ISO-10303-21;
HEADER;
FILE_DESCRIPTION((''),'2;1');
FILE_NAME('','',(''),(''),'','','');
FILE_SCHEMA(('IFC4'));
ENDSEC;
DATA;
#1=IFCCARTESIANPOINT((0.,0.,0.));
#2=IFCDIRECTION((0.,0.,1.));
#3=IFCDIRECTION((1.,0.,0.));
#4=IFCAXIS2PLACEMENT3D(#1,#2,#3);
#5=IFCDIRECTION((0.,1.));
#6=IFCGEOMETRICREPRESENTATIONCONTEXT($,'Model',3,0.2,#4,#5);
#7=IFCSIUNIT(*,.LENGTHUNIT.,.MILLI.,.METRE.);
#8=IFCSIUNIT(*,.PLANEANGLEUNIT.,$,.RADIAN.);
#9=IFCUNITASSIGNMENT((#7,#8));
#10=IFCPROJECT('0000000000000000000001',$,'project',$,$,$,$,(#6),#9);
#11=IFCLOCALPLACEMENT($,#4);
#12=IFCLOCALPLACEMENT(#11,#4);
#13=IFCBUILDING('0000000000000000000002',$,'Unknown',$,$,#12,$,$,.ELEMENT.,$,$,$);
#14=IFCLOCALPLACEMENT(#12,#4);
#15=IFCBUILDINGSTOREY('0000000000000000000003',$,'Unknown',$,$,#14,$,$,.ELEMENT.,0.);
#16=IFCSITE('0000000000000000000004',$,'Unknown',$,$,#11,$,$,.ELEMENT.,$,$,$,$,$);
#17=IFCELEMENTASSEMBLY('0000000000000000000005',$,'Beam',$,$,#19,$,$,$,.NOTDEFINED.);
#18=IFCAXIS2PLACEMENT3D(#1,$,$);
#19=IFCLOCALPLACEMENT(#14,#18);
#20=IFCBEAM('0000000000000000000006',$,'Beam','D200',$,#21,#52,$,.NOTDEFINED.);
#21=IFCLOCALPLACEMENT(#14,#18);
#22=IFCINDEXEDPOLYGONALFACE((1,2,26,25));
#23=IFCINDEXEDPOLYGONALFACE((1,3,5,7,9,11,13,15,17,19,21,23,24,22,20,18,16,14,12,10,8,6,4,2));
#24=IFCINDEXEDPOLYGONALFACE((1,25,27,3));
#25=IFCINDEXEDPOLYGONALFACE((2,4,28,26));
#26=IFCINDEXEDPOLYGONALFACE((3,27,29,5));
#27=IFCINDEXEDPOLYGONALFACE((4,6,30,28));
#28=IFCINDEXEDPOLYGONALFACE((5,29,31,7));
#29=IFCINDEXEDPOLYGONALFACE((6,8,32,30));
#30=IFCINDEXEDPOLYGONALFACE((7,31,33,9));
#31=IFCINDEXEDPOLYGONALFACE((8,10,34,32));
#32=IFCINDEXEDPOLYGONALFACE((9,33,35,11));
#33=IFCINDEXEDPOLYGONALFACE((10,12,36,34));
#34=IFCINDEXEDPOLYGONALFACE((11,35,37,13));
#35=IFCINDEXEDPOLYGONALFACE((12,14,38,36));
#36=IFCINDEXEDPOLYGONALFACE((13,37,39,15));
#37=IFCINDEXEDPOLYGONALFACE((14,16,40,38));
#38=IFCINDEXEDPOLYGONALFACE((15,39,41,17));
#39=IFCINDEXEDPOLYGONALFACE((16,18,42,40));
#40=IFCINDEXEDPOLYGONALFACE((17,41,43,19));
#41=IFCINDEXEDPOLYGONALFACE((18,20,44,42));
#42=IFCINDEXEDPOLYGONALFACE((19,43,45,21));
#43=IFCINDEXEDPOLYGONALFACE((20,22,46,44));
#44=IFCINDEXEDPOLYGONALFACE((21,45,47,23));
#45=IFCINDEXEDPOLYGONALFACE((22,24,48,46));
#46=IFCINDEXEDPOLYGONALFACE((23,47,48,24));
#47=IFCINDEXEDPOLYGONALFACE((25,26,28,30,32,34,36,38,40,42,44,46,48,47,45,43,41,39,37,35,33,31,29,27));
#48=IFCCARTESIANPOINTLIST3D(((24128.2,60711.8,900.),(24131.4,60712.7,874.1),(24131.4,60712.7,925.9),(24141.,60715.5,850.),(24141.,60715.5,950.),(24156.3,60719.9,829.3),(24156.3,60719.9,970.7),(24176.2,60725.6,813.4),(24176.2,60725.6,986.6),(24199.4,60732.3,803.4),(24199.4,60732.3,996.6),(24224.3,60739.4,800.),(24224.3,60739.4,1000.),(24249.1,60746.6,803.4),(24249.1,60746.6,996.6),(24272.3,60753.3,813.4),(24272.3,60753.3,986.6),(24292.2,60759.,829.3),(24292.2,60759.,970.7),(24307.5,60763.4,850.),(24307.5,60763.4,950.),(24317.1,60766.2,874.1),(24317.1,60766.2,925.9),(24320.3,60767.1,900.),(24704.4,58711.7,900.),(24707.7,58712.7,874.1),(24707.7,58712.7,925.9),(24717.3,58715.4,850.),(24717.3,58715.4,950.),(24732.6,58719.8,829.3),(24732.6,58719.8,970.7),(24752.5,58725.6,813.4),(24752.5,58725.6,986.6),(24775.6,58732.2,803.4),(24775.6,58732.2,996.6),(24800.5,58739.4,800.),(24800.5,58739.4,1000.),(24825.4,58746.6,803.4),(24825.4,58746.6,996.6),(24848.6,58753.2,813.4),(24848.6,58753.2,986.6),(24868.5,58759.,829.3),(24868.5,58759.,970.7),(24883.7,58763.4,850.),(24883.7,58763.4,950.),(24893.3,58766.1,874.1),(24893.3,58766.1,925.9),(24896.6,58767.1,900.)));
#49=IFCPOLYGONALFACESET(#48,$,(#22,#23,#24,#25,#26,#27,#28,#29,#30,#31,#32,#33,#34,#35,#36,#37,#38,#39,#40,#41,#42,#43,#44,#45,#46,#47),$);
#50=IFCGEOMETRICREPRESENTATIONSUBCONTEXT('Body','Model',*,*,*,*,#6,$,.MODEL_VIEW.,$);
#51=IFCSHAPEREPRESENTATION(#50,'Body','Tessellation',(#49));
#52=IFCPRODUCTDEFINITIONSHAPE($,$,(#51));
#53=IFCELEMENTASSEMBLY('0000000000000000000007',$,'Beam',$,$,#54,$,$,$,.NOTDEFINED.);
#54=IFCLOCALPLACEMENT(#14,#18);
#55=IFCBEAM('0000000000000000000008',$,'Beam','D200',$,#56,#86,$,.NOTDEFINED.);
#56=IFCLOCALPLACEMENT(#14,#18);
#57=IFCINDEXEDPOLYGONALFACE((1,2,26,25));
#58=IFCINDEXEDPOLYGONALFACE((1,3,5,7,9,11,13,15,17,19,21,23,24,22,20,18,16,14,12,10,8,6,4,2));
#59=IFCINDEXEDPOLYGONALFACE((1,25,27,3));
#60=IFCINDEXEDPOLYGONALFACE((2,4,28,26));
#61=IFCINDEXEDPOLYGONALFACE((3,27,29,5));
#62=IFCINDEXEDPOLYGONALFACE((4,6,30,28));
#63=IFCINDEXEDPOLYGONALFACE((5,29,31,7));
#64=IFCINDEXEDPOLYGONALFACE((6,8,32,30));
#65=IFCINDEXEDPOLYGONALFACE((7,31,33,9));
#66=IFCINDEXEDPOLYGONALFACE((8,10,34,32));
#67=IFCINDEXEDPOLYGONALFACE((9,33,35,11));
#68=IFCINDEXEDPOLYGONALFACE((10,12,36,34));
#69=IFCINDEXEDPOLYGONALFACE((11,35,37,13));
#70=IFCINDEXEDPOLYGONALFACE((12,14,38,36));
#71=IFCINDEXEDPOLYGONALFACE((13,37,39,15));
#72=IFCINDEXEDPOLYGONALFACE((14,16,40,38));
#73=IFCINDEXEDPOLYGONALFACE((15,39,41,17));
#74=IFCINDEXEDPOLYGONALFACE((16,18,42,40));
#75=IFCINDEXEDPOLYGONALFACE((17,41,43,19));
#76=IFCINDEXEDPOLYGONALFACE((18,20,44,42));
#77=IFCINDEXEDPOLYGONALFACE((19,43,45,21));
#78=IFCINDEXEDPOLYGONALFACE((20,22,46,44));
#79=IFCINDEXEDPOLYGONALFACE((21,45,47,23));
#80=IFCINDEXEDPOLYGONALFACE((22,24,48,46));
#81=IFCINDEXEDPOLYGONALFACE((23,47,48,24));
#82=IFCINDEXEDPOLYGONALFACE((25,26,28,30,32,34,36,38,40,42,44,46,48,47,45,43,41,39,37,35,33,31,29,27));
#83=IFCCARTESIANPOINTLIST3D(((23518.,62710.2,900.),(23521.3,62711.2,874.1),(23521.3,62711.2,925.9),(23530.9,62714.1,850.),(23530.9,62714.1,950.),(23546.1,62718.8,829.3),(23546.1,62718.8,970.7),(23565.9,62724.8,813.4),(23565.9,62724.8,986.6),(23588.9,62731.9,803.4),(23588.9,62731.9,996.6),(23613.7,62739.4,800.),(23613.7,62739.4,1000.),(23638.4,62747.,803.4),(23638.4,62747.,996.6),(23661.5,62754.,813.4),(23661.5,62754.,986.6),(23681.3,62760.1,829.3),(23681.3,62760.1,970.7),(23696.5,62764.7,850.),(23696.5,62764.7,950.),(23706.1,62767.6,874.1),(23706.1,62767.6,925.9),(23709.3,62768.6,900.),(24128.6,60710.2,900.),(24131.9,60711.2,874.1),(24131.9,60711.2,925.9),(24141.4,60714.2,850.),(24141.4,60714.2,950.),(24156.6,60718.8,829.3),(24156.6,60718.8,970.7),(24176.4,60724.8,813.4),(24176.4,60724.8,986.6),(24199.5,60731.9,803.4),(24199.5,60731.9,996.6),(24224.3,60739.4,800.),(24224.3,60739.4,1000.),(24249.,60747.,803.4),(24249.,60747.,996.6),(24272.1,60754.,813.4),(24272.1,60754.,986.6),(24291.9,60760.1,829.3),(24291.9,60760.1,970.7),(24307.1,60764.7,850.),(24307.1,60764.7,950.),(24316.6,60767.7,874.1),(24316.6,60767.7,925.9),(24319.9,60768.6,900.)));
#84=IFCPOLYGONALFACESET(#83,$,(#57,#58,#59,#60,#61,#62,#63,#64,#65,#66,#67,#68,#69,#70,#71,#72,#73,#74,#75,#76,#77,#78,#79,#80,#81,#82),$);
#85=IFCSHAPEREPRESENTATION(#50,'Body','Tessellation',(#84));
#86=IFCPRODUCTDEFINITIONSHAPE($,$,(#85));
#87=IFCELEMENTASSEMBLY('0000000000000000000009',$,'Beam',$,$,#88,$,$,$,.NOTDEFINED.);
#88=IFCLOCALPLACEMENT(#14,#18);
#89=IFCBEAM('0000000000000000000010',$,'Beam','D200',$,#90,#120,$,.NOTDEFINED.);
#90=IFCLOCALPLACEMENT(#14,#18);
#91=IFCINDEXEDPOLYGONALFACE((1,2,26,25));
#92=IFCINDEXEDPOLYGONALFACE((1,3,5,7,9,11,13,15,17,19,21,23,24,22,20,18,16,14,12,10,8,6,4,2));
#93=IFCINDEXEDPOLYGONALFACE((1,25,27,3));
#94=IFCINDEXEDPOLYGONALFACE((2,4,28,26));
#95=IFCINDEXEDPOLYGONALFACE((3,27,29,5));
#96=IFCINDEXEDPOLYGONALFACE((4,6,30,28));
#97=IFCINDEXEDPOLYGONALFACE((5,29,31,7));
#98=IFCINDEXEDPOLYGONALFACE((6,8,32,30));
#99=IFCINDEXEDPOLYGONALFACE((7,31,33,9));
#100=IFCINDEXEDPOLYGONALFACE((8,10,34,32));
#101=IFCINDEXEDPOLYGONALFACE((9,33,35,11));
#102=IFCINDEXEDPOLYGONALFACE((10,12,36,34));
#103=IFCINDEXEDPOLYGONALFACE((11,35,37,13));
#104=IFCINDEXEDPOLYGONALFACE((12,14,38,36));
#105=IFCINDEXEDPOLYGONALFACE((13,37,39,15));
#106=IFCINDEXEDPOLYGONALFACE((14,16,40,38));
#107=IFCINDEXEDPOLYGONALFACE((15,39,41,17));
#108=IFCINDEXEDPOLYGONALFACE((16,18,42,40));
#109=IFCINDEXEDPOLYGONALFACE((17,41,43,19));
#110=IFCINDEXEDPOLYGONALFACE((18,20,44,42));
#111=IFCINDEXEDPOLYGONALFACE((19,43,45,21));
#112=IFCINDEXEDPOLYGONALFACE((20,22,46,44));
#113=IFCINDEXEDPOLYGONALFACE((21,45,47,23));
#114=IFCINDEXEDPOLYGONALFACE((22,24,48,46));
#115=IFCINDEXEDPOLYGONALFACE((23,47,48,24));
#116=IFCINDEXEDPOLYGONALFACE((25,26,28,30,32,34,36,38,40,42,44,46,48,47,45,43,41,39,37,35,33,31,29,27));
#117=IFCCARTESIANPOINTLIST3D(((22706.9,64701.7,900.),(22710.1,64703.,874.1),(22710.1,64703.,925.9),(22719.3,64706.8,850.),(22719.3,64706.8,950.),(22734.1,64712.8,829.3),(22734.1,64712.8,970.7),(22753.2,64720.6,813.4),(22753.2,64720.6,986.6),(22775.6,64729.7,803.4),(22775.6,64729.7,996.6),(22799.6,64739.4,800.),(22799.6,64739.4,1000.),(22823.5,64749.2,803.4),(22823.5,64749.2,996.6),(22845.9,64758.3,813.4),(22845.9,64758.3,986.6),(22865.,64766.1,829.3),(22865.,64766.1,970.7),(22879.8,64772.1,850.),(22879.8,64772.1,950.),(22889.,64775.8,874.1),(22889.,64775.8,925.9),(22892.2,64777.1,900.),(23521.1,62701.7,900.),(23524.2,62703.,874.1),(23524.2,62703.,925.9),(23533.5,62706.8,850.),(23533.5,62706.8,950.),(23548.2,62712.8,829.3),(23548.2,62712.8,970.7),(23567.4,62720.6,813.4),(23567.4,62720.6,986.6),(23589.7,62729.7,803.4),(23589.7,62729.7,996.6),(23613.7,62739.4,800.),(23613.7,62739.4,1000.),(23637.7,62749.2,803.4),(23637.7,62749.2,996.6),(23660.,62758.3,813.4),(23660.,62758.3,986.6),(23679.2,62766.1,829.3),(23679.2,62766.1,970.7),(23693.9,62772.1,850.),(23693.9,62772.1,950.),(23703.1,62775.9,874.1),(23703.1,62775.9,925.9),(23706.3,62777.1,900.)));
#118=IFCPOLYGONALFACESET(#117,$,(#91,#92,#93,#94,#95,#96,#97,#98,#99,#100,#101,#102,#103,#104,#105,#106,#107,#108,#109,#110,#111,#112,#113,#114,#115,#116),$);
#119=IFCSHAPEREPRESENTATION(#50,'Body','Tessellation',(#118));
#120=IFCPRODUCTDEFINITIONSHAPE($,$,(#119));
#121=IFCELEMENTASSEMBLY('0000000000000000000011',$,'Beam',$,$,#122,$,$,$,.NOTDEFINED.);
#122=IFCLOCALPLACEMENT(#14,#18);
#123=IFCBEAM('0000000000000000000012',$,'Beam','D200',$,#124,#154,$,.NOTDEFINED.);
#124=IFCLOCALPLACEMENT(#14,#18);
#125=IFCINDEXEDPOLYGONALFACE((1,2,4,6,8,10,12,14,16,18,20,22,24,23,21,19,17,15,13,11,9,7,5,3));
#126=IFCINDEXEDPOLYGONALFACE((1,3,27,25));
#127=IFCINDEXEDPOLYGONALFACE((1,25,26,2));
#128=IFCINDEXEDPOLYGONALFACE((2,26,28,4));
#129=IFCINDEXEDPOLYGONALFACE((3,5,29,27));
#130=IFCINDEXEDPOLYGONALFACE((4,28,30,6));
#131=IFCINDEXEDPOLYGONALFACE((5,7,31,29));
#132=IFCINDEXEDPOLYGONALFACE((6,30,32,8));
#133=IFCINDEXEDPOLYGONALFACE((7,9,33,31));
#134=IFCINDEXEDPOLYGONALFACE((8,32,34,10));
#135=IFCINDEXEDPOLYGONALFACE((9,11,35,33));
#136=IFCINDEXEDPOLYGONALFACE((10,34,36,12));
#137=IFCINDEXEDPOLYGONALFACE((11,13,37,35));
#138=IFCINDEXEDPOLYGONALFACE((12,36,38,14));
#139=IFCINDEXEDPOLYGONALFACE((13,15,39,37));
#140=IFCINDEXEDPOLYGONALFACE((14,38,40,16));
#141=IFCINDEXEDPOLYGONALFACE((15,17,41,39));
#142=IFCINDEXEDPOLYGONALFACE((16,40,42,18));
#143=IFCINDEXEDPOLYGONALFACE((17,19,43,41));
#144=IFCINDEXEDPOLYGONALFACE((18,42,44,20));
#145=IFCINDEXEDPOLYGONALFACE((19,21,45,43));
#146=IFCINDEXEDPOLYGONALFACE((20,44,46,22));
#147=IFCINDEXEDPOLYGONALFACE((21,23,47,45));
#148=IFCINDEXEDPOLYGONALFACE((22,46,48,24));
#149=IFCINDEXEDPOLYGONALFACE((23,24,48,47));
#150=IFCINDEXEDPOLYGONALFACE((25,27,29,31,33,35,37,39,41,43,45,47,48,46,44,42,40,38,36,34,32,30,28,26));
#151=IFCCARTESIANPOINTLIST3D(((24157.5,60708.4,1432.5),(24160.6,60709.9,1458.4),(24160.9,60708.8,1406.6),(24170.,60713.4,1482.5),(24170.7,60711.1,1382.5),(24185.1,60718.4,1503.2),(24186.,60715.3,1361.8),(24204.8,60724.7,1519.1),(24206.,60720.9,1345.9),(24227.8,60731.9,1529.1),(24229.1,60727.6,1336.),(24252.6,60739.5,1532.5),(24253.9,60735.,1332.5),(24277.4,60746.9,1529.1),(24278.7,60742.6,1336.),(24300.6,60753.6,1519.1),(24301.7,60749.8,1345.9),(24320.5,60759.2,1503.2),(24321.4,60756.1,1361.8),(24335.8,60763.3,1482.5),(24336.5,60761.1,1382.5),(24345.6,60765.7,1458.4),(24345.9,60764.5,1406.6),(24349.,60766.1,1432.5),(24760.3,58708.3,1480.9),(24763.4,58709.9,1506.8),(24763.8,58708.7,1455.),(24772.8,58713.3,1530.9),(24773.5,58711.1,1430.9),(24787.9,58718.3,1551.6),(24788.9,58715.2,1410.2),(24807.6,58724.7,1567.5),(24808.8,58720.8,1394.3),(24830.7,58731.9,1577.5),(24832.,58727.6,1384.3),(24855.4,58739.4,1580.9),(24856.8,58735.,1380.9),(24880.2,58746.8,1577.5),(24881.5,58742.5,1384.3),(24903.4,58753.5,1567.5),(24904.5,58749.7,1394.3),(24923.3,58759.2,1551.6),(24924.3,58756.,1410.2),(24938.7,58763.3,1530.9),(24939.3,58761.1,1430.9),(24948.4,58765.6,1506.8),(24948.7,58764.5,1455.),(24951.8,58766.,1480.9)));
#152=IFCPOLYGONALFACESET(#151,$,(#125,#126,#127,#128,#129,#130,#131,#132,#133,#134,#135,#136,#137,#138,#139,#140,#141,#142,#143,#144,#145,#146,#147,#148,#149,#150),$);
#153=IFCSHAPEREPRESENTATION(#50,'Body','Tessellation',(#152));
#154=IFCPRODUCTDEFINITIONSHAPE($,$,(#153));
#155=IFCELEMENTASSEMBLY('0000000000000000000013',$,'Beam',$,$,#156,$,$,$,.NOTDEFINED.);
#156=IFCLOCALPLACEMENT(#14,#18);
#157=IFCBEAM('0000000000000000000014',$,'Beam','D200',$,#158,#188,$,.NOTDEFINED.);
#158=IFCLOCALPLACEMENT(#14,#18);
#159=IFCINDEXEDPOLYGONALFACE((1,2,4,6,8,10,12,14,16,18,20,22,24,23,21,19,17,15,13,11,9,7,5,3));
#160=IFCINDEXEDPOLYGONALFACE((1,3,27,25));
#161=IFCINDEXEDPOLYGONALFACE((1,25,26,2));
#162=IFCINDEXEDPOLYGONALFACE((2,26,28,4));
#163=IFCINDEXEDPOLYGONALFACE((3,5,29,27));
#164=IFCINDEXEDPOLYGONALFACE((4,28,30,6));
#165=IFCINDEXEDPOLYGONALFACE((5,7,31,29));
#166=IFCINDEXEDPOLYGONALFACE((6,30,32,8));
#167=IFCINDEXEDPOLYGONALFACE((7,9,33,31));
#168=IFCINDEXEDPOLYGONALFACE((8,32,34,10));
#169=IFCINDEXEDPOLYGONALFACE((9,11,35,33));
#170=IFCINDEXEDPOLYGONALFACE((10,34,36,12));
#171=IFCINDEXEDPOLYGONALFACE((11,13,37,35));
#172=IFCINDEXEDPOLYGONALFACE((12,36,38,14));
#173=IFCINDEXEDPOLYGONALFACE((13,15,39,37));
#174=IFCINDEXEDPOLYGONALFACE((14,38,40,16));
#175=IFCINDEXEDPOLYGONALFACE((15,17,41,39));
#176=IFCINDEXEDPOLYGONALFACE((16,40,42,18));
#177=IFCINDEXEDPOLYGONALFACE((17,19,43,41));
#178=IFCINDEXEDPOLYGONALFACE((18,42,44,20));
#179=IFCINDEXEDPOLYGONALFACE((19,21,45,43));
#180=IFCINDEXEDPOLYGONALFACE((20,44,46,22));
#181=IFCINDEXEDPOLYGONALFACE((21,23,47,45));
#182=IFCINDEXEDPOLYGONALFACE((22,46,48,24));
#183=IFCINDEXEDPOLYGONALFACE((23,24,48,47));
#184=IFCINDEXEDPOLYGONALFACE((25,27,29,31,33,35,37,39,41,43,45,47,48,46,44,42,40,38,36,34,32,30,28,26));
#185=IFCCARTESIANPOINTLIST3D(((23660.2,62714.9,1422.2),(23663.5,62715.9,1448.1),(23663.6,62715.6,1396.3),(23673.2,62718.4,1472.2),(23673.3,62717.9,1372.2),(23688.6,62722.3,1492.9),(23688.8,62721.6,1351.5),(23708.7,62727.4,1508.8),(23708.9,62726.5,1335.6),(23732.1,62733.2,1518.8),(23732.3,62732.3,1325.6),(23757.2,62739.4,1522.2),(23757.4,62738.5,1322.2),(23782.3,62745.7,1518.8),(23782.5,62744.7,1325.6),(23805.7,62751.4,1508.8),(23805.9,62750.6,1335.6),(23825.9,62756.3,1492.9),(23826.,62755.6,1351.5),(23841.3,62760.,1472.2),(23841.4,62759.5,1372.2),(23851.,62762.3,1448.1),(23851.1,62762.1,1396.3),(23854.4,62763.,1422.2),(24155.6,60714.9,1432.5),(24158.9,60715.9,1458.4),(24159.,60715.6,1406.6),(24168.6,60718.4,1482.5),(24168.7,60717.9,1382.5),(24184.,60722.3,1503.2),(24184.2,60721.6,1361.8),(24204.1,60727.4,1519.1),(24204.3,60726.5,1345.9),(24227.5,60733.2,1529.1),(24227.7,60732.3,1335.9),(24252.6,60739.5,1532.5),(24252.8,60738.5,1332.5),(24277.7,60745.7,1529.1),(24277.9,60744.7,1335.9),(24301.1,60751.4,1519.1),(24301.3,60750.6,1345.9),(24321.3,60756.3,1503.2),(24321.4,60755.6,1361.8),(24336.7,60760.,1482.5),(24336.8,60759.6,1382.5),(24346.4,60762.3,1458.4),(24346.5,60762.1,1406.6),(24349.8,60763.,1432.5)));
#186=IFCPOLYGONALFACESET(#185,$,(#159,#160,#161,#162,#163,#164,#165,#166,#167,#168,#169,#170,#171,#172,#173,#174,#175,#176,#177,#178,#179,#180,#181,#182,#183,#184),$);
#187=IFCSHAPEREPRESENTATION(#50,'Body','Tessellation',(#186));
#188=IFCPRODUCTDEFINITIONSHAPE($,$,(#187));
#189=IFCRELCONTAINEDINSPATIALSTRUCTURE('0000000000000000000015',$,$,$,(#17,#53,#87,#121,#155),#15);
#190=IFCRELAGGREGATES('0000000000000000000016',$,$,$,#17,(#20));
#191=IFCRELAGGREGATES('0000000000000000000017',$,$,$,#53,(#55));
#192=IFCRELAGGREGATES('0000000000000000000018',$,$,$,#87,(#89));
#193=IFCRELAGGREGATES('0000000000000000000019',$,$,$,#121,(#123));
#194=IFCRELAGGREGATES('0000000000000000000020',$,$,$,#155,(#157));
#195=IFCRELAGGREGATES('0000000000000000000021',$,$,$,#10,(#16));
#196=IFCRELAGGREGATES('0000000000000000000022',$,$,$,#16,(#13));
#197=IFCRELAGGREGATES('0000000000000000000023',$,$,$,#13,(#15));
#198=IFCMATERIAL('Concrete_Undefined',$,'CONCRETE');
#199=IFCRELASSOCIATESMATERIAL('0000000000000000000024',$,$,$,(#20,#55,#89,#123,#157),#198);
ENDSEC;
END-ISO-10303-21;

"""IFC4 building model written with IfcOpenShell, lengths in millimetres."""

from ifc_helpers import new_model, si_unit, direction, frame, origin_with_axes, place, context, subcontext, project, spatial, line, indexed_curve, outline, extrude, material, element, aggregate, save


model = new_model("IFC4")

# Units and contexts
model_context = context("Model", 3, precision=0.2, world=origin_with_axes(), true_north=direction((0.0, 1.0)))
body_context = subcontext(model_context, "Body", "Model", "MODEL_VIEW")
ifc_project = project(units=[si_unit("LENGTHUNIT", "METRE", prefix="MILLI"), si_unit("PLANEANGLEUNIT", "RADIAN")], contexts=[model_context])

# Site, building, storey
site_placement = place(None, origin_with_axes())
site = spatial("IfcSite", under=ifc_project, at=site_placement, Name="Unknown", CompositionType="ELEMENT")
building_placement = place(site_placement, origin_with_axes())
building = spatial("IfcBuilding", under=site, at=building_placement, Name="Unknown", CompositionType="ELEMENT")
storey_placement = place(building_placement, origin_with_axes())
storey = spatial("IfcBuildingStorey", under=building, at=storey_placement, Name="Unknown", CompositionType="ELEMENT", Elevation=0.0)

# Element assemblies, beams
assembly_1_placement = place(storey_placement, frame((24224.3, 60739.4, 900.0), z_axis=(-0.960911, -0.276858, 0.0), x_axis=(0.276858, -0.960911, 0.0)))
assembly_1 = element("IfcElementAssembly", 1, at=assembly_1_placement, inside=storey, Name="Beam", PredefinedType="NOTDEFINED")
ifc_material = material(Name="Concrete_Undefined", Category="CONCRETE")
beam_1_placement = place(assembly_1_placement, origin_with_axes())
beam_1 = element("IfcBeam", 2, at=beam_1_placement, material=ifc_material, Name="Beam", Description="D200", PredefinedType="NOTDEFINED", context=body_context, shape_type="SolidModel", body=[
    extrude(outline(indexed_curve([(100.0, 0.0), (96.6, 25.9), (86.6, 50.0), (70.7, 70.7), (50.0, 86.6), (25.9, 96.6), (0.0, 100.0), (-25.9, 96.6), (-50.0, 86.6), (-70.7, 70.7), (-86.6, 50.0), (-96.6, 25.9), (-100.0, 0.0), (-96.6, -25.9), (-86.6, -50.0), (-70.7, -70.7), (-50.0, -86.6), (-25.9, -96.6), (0.0, -100.0), (25.9, -96.6), (50.0, -86.6), (70.7, -70.7), (86.6, -50.0), (96.6, -25.9)], segments=[line(1, 2, 3, 4, 5, 6, 7, 8, 9, 10, 11, 12, 13, 14, 15, 16, 17, 18, 19, 20, 21, 22, 23, 24, 1)])), frame((0.0, 0.0, 0.0), z_axis=(-1.0, 0.0, 0.0), x_axis=(0.0, 0.0, 1.0)), (0.0, 0.0, -1.0), 2081.4),
])
aggregate(assembly_1, [beam_1])
assembly_2_placement = place(storey_placement, frame((23613.7, 62739.4, 900.0), z_axis=(-0.956423, -0.291984, 0.0), x_axis=(0.291984, -0.956423, 0.0)))
assembly_2 = element("IfcElementAssembly", 3, at=assembly_2_placement, inside=storey, Name="Beam", PredefinedType="NOTDEFINED")
beam_2_placement = place(assembly_2_placement, origin_with_axes())
beam_2 = element("IfcBeam", 4, at=beam_2_placement, material=ifc_material, Name="Beam", Description="D200", PredefinedType="NOTDEFINED", context=body_context, shape_type="SolidModel", body=[
    extrude(outline(indexed_curve([(100.0, 0.0), (96.6, 25.9), (86.6, 50.0), (70.7, 70.7), (50.0, 86.6), (25.9, 96.6), (0.0, 100.0), (-25.9, 96.6), (-50.0, 86.6), (-70.7, 70.7), (-86.6, 50.0), (-96.6, 25.9), (-100.0, 0.0), (-96.6, -25.9), (-86.6, -50.0), (-70.7, -70.7), (-50.0, -86.6), (-25.9, -96.6), (0.0, -100.0), (25.9, -96.6), (50.0, -86.6), (70.7, -70.7), (86.6, -50.0), (96.6, -25.9)], segments=[line(1, 2, 3, 4, 5, 6, 7, 8, 9, 10, 11, 12, 13, 14, 15, 16, 17, 18, 19, 20, 21, 22, 23, 24, 1)])), frame((0.0, 0.0, 0.0), z_axis=(-1.0, 0.0, 0.0), x_axis=(0.0, 0.0, 1.0)), (0.0, 0.0, -1.0), 2091.1),
])
aggregate(assembly_2, [beam_2])
assembly_3_placement = place(storey_placement, frame((22799.6, 64739.4, 900.0), z_axis=(-0.926202, -0.377027, 0.0), x_axis=(0.377027, -0.926202, 0.0)))
assembly_3 = element("IfcElementAssembly", 5, at=assembly_3_placement, inside=storey, Name="Beam", PredefinedType="NOTDEFINED")
beam_3_placement = place(assembly_3_placement, origin_with_axes())
beam_3 = element("IfcBeam", 6, at=beam_3_placement, material=ifc_material, Name="Beam", Description="D200", PredefinedType="NOTDEFINED", context=body_context, shape_type="SolidModel", body=[
    extrude(outline(indexed_curve([(100.0, 0.0), (96.6, 25.9), (86.6, 50.0), (70.7, 70.7), (50.0, 86.6), (25.9, 96.6), (0.0, 100.0), (-25.9, 96.6), (-50.0, 86.6), (-70.7, 70.7), (-86.6, 50.0), (-96.6, 25.9), (-100.0, 0.0), (-96.6, -25.9), (-86.6, -50.0), (-70.7, -70.7), (-50.0, -86.6), (-25.9, -96.6), (0.0, -100.0), (25.9, -96.6), (50.0, -86.6), (70.7, -70.7), (86.6, -50.0), (96.6, -25.9)], segments=[line(1, 2, 3, 4, 5, 6, 7, 8, 9, 10, 11, 12, 13, 14, 15, 16, 17, 18, 19, 20, 21, 22, 23, 24, 1)])), frame((0.0, 0.0, 0.0), z_axis=(-1.0, 0.0, 0.0), x_axis=(0.0, 0.0, 1.0)), (0.0, 0.0, -1.0), 2159.3),
])
aggregate(assembly_3, [beam_3])
assembly_4_placement = place(storey_placement, frame((24253.3, 60737.2, 1432.5), z_axis=(-0.957455, -0.288582, 0.0), x_axis=(0.288504, -0.957198, 0.02316)))
assembly_4 = element("IfcElementAssembly", 7, at=assembly_4_placement, inside=storey, Name="Beam", PredefinedType="NOTDEFINED")
beam_4_placement = place(assembly_4_placement, origin_with_axes())
beam_4 = element("IfcBeam", 8, at=beam_4_placement, material=ifc_material, Name="Beam", Description="D200", PredefinedType="NOTDEFINED", context=body_context, shape_type="SolidModel", body=[
    extrude(outline(indexed_curve([(100.0, 0.0), (96.6, 25.9), (86.6, 50.0), (70.7, 70.7), (50.0, 86.6), (25.9, 96.6), (0.0, 100.0), (-25.9, 96.6), (-50.0, 86.6), (-70.7, 70.7), (-86.6, 50.0), (-96.6, 25.9), (-100.0, 0.0), (-96.6, -25.9), (-86.6, -50.0), (-70.7, -70.7), (-50.0, -86.6), (-25.9, -96.6), (0.0, -100.0), (25.9, -96.6), (50.0, -86.6), (70.7, -70.7), (86.6, -50.0), (96.6, -25.9)], segments=[line(1, 2, 3, 4, 5, 6, 7, 8, 9, 10, 11, 12, 13, 14, 15, 16, 17, 18, 19, 20, 21, 22, 23, 24, 1)])), frame((0.0, 0.0, 0.0), z_axis=(-1.0, 0.0, 0.0), x_axis=(0.0, 0.0, 1.0)), (0.0, 0.0, -1.0), 2089.5),
])
aggregate(assembly_4, [beam_4])
assembly_5_placement = place(storey_placement, frame((23757.3, 62739.0, 1422.2), z_axis=(-0.970664, -0.240439, 0.0), x_axis=(0.240436, -0.970652, 0.004986)))
assembly_5 = element("IfcElementAssembly", 9, at=assembly_5_placement, inside=storey, Name="Beam", PredefinedType="NOTDEFINED")
beam_5_placement = place(assembly_5_placement, origin_with_axes())
beam_5 = element("IfcBeam", 10, at=beam_5_placement, material=ifc_material, Name="Beam", Description="D200", PredefinedType="NOTDEFINED", context=body_context, shape_type="SolidModel", body=[
    extrude(outline(indexed_curve([(100.0, 0.0), (96.6, 25.9), (86.6, 50.0), (70.7, 70.7), (50.0, 86.6), (25.9, 96.6), (0.0, 100.0), (-25.9, 96.6), (-50.0, 86.6), (-70.7, 70.7), (-86.6, 50.0), (-96.6, 25.9), (-100.0, 0.0), (-96.6, -25.9), (-86.6, -50.0), (-70.7, -70.7), (-50.0, -86.6), (-25.9, -96.6), (0.0, -100.0), (25.9, -96.6), (50.0, -86.6), (70.7, -70.7), (86.6, -50.0), (96.6, -25.9)], segments=[line(1, 2, 3, 4, 5, 6, 7, 8, 9, 10, 11, 12, 13, 14, 15, 16, 17, 18, 19, 20, 21, 22, 23, 24, 1)])), frame((0.0, 0.0, 0.0), z_axis=(-1.0, 0.0, 0.0), x_axis=(0.0, 0.0, 1.0)), (0.0, 0.0, -1.0), 2060.5),
])
aggregate(assembly_5, [beam_5])

save(model, "model.ifc")
